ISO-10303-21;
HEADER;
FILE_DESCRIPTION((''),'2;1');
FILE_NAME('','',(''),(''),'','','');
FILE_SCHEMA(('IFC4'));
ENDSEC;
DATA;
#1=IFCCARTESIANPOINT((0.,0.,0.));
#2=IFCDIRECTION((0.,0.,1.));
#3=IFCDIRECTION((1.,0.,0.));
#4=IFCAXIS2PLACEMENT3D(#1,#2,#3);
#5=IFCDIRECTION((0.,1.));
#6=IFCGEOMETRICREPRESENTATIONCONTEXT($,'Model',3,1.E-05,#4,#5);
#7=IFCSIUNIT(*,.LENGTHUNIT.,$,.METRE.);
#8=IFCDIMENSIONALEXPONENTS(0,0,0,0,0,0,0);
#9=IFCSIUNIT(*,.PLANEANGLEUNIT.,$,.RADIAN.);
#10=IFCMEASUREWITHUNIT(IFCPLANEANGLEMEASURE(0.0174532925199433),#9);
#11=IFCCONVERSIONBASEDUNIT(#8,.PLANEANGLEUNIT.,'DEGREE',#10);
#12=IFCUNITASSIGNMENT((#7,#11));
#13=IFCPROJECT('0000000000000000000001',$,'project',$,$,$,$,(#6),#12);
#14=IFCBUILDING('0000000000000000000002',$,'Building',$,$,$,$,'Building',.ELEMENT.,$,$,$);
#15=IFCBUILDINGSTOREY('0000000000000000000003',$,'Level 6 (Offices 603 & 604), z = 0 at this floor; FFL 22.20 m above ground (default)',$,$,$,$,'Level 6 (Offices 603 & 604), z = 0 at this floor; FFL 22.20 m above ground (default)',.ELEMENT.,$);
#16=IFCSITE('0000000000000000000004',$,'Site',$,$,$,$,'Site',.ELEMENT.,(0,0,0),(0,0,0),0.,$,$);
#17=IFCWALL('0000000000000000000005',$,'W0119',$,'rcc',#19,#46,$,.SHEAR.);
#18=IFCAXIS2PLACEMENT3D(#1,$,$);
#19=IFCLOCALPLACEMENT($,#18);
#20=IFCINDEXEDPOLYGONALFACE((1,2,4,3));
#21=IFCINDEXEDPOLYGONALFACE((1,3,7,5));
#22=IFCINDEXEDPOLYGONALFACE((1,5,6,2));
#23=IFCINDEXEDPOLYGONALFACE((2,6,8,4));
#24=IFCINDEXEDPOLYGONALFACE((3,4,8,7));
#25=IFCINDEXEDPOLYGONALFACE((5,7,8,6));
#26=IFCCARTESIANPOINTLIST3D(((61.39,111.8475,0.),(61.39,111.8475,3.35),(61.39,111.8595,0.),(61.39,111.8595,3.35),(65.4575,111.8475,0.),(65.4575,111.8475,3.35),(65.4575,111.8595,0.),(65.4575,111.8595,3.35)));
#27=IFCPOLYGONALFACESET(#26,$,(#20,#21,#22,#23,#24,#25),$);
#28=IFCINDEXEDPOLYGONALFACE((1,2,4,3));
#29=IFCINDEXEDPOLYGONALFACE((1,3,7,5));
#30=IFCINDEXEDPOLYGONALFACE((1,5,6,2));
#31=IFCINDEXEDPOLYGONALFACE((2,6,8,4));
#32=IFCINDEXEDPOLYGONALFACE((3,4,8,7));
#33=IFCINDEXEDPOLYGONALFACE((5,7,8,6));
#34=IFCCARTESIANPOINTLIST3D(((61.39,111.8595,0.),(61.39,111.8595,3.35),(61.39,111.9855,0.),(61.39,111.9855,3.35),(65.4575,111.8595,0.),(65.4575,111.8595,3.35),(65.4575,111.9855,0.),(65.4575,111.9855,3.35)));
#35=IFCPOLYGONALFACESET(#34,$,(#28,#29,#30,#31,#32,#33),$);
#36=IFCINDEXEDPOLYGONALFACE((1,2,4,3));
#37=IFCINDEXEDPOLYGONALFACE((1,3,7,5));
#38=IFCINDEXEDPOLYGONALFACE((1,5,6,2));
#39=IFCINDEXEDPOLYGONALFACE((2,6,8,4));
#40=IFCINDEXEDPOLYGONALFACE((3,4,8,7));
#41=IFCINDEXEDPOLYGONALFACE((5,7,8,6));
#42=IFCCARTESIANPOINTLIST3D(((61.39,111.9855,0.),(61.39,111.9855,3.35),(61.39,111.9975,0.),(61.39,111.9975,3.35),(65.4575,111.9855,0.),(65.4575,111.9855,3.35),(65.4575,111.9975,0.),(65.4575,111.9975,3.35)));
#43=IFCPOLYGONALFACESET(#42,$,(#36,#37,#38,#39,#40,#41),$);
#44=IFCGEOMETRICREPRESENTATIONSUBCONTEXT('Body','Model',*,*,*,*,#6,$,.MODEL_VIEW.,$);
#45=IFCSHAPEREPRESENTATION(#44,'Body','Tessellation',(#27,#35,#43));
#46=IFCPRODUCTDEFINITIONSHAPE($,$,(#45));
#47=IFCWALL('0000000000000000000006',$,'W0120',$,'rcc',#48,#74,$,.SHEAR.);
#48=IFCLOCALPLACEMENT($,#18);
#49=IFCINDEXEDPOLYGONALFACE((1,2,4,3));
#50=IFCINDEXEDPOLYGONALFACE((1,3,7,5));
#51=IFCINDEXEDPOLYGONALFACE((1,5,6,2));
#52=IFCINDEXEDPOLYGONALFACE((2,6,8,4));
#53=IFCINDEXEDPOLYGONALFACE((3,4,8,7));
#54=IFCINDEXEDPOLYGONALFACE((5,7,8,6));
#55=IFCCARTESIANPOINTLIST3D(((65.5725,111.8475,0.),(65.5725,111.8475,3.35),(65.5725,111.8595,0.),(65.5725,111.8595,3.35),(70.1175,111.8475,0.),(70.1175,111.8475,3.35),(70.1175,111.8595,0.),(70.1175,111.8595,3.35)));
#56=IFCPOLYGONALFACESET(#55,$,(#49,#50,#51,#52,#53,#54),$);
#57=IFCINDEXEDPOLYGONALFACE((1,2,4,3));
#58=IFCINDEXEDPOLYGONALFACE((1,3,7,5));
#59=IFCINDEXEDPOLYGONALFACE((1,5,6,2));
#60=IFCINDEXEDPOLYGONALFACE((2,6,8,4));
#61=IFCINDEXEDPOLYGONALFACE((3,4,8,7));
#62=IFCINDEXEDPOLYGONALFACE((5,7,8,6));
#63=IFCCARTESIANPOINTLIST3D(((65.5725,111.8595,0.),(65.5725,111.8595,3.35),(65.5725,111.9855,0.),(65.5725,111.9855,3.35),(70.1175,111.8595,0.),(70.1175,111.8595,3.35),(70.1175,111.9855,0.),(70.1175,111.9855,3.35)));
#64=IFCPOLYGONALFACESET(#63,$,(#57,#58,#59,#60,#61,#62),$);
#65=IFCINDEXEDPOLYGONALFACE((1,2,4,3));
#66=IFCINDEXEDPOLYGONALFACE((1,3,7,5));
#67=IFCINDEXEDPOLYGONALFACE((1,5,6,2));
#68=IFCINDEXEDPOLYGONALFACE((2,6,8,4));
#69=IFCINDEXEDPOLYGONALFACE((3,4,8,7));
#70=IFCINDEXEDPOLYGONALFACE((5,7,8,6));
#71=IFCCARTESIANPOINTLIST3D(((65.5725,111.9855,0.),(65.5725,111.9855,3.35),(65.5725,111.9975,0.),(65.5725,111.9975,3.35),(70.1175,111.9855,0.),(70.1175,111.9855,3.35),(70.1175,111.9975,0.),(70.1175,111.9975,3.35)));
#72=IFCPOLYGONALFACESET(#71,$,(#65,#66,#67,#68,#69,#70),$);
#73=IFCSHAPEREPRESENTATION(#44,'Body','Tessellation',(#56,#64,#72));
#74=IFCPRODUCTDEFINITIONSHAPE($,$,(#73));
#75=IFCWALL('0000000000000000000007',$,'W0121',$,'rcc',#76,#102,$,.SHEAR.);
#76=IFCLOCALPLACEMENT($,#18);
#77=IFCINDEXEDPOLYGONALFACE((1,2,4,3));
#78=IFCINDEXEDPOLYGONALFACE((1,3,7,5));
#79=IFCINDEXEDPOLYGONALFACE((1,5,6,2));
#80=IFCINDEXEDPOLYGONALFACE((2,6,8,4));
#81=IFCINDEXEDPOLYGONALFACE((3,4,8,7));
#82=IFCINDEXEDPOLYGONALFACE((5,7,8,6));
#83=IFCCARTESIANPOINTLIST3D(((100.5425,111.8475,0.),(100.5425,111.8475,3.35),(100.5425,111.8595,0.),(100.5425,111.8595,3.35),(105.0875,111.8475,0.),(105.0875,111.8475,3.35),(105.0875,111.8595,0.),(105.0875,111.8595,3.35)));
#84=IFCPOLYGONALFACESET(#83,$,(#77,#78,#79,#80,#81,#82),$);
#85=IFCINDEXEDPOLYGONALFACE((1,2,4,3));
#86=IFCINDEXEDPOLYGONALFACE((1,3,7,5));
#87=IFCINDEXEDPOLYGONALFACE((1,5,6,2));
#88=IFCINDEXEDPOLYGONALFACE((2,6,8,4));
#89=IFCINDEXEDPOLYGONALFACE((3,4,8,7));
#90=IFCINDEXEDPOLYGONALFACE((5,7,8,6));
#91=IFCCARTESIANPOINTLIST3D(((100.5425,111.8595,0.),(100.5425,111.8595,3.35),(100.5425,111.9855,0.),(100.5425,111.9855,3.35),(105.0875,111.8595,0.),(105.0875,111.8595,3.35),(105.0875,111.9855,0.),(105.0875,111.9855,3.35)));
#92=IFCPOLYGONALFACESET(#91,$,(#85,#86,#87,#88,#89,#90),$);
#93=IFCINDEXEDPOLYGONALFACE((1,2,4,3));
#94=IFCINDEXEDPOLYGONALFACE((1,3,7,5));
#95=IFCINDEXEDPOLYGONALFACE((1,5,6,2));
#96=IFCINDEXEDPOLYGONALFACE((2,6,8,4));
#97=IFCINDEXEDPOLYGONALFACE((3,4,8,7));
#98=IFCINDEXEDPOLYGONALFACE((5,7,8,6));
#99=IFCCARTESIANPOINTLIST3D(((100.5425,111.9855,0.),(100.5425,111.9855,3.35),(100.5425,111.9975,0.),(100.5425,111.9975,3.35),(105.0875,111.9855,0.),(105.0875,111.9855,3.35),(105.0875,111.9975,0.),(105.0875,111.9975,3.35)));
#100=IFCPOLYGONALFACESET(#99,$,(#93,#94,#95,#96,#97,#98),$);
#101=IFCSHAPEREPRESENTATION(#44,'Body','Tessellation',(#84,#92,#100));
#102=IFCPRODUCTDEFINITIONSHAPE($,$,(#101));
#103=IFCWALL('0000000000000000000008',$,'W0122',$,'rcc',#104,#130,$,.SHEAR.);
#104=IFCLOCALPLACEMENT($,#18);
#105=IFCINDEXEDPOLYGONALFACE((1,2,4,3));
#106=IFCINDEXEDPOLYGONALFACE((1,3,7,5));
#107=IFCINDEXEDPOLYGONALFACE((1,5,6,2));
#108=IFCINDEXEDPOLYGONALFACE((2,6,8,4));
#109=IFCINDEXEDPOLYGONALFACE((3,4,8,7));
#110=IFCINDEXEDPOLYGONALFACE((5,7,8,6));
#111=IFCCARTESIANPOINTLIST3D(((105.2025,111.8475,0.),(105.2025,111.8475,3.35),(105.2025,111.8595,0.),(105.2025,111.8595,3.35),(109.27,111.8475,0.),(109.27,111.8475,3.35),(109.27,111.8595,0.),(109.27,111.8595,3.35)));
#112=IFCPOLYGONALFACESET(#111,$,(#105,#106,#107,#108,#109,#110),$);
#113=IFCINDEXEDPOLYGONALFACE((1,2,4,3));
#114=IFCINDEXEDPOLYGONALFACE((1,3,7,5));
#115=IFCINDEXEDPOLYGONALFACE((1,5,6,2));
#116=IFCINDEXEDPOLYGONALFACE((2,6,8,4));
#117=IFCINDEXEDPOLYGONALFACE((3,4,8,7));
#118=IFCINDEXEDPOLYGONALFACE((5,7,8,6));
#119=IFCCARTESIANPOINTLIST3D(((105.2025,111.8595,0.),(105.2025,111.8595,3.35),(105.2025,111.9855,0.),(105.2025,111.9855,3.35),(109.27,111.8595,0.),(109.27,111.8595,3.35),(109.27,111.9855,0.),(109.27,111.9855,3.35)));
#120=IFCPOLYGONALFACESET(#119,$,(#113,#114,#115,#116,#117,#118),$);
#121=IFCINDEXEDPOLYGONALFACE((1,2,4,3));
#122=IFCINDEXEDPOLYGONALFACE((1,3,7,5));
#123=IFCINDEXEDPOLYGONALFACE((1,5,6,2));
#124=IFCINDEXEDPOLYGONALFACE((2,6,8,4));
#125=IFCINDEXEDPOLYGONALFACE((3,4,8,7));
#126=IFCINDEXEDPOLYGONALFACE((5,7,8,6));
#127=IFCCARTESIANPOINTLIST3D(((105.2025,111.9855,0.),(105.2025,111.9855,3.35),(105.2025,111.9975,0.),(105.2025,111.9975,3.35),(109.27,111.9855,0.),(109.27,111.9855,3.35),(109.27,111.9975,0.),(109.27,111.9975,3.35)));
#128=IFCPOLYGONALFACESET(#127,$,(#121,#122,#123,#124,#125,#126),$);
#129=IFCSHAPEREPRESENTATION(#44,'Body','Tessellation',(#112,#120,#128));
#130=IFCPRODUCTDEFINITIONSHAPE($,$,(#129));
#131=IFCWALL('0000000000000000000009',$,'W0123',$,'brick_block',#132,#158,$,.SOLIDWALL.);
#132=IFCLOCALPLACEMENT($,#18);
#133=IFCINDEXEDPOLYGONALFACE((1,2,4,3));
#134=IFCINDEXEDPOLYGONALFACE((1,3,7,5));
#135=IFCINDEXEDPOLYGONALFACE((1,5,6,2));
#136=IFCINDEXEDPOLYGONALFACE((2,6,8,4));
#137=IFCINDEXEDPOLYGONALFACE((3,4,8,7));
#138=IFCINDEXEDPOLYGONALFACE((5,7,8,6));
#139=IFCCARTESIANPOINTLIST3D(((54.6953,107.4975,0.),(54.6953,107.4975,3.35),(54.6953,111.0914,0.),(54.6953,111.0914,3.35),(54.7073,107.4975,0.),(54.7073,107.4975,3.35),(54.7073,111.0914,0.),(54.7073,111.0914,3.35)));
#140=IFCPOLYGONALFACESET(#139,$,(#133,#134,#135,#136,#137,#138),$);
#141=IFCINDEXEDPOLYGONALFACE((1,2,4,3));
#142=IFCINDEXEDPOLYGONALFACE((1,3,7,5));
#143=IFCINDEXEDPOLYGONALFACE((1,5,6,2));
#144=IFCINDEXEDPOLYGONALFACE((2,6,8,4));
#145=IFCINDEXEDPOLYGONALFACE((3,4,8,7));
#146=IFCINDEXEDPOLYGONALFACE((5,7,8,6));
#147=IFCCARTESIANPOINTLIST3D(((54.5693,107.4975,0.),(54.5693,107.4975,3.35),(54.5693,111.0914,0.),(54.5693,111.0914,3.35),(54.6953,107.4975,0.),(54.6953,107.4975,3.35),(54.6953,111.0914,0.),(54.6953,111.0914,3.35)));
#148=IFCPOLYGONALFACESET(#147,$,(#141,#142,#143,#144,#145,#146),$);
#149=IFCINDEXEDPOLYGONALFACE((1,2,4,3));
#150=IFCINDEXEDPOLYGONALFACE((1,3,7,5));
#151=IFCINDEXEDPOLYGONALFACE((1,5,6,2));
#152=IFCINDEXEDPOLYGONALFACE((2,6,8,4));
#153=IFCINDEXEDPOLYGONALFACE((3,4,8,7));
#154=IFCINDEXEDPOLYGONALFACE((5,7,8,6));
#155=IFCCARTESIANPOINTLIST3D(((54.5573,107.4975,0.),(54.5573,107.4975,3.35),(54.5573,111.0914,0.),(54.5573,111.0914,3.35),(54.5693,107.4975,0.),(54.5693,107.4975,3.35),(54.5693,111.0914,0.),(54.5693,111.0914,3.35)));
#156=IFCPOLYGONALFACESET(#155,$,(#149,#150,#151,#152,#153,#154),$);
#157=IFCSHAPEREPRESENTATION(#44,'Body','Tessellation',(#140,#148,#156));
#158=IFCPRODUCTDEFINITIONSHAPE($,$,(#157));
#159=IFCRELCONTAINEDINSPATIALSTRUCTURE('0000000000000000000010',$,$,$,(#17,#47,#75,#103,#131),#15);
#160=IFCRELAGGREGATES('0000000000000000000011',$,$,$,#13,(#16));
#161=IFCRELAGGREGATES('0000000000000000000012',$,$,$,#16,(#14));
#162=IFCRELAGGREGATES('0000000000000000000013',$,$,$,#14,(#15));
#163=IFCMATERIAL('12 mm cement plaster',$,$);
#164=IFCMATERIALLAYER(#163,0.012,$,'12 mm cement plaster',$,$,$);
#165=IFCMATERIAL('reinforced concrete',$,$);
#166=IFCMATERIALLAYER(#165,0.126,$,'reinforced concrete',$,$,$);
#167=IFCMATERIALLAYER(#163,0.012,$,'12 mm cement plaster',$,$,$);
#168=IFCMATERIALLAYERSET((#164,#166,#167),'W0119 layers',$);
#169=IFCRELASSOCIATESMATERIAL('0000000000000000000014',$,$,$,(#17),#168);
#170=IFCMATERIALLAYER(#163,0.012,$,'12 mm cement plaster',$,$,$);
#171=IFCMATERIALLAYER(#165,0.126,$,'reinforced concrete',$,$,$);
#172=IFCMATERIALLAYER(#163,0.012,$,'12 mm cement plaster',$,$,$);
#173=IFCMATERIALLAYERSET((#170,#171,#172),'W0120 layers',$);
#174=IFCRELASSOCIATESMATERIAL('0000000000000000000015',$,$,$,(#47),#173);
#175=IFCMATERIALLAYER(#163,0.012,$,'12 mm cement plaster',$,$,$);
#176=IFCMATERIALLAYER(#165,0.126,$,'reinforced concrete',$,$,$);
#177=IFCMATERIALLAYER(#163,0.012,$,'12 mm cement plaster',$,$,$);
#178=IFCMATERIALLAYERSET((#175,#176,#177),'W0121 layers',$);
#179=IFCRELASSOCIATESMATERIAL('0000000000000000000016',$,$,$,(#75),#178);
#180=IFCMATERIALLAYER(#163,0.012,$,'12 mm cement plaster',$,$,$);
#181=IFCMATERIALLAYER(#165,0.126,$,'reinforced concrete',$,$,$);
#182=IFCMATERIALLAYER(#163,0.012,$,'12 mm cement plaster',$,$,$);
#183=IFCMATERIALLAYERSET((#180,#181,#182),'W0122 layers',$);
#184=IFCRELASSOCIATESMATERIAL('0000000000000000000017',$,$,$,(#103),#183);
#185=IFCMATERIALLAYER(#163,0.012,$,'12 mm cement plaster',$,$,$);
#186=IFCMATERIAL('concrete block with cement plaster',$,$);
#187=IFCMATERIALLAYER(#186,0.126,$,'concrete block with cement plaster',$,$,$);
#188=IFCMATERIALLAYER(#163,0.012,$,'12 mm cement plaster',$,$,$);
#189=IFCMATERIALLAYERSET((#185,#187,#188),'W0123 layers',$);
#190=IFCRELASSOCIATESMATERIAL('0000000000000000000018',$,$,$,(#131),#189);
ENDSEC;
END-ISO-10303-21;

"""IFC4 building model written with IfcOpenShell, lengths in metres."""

from ifc_helpers import new_model, entity, si_unit, converted_unit, direction, frame, frame_2d, origin_with_axes, origin_2d_with_axis, place, context, subcontext, project, spatial, rectangle, extrude, material, layer, layer_set, layer_usage, element, save


model = new_model("IFC4")

# Units and contexts
model_context = context("Model", 3, precision=1e-05, world=origin_with_axes(), true_north=direction((0.0, 1.0)))
body_context = subcontext(model_context, "Body", "Model", "MODEL_VIEW")
ifc_project = project(units=[si_unit("LENGTHUNIT", "METRE"), converted_unit("PLANEANGLEUNIT", "DEGREE", entity("IfcPlaneAngleMeasure", 0.0174532925199433), si_unit("PLANEANGLEUNIT", "RADIAN"), dimensions=[0, 0, 0, 0, 0, 0, 0])], contexts=[model_context])

# Site, building, storey
site = spatial("IfcSite", under=ifc_project, Name="Site", LongName="Site", CompositionType="ELEMENT", RefLatitude=(0, 0, 0), RefLongitude=(0, 0, 0), RefElevation=0.0)
building = spatial("IfcBuilding", under=site, Name="Building", LongName="Building", CompositionType="ELEMENT")
storey = spatial("IfcBuildingStorey", under=building, Name="Level 6 (Offices 603 & 604), z = 0 at this floor; FFL 22.20 m above ground (default)", LongName="Level 6 (Offices 603 & 604), z = 0 at this floor; FFL 22.20 m above ground (default)", CompositionType="ELEMENT")

# Shared definitions
placement = place(None, origin_with_axes())

# Walls
ifc_material_1 = material(Name="12 mm cement plaster")
ifc_material_2 = material(Name="concrete block with cement plaster")
ifc_layer_1 = layer(ifc_material_1, 0.012, Name="12 mm cement plaster")
ifc_material_3 = material(Name="reinforced concrete")
ifc_layer_2 = layer(ifc_material_3, 0.126, Name="reinforced concrete")
ifc_layer_3 = layer(ifc_material_1, 0.012, Name="12 mm cement plaster")
ifc_layer_set_1 = layer_set([ifc_layer_1, ifc_layer_2, ifc_layer_3], Name="W0119 layers")
ifc_layer_usage_1 = layer_usage(ifc_layer_set_1, "AXIS2", "POSITIVE", -0.075)
element("IfcWall", 1, at=placement, inside=storey, material=ifc_layer_usage_1, Name="W0119", ObjectType="rcc", PredefinedType="SHEAR", context=body_context, shape_type="SweptSolid", body=[
    extrude(rectangle(XDim=4.0675, YDim=0.012, at=frame_2d((0.0, 0.0), x_axis=(1.0, 0.0))), frame((63.4237, 111.8535, 0.0), z_axis=(0.0, 0.0, 1.0), x_axis=(1.0, 0.0, 0.0)), (0.0, 0.0, 1.0), 3.35),
    extrude(rectangle(XDim=4.0675, YDim=0.126, at=frame_2d((0.0, 0.069), x_axis=(1.0, 0.0))), frame((63.4237, 111.8535, 0.0), z_axis=(0.0, 0.0, 1.0), x_axis=(1.0, 0.0, 0.0)), (0.0, 0.0, 1.0), 3.35),
    extrude(rectangle(XDim=4.0675, YDim=0.012, at=frame_2d((0.0, 0.138), x_axis=(1.0, 0.0))), frame((63.4237, 111.8535, 0.0), z_axis=(0.0, 0.0, 1.0), x_axis=(1.0, 0.0, 0.0)), (0.0, 0.0, 1.0), 3.35),
])
ifc_layer_4 = layer(ifc_material_1, 0.012, Name="12 mm cement plaster")
ifc_layer_5 = layer(ifc_material_3, 0.126, Name="reinforced concrete")
ifc_layer_6 = layer(ifc_material_1, 0.012, Name="12 mm cement plaster")
ifc_layer_set_2 = layer_set([ifc_layer_4, ifc_layer_5, ifc_layer_6], Name="W0120 layers")
ifc_layer_usage_2 = layer_usage(ifc_layer_set_2, "AXIS2", "POSITIVE", -0.075)
element("IfcWall", 2, at=placement, inside=storey, material=ifc_layer_usage_2, Name="W0120", ObjectType="rcc", PredefinedType="SHEAR", context=body_context, shape_type="SweptSolid", body=[
    extrude(rectangle(XDim=4.545, YDim=0.012, at=origin_2d_with_axis()), frame((67.845, 111.8535, 0.0), z_axis=(0.0, 0.0, 1.0), x_axis=(1.0, 0.0, 0.0)), (0.0, 0.0, 1.0), 3.35),
    extrude(rectangle(XDim=4.545, YDim=0.126, at=frame_2d((0.0, 0.069), x_axis=(1.0, 0.0))), frame((67.845, 111.8535, 0.0), z_axis=(0.0, 0.0, 1.0), x_axis=(1.0, 0.0, 0.0)), (0.0, 0.0, 1.0), 3.35),
    extrude(rectangle(XDim=4.545, YDim=0.012, at=frame_2d((0.0, 0.138), x_axis=(1.0, 0.0))), frame((67.845, 111.8535, 0.0), z_axis=(0.0, 0.0, 1.0), x_axis=(1.0, 0.0, 0.0)), (0.0, 0.0, 1.0), 3.35),
])
ifc_layer_7 = layer(ifc_material_1, 0.012, Name="12 mm cement plaster")
ifc_layer_8 = layer(ifc_material_3, 0.126, Name="reinforced concrete")
ifc_layer_9 = layer(ifc_material_1, 0.012, Name="12 mm cement plaster")
ifc_layer_set_3 = layer_set([ifc_layer_7, ifc_layer_8, ifc_layer_9], Name="W0121 layers")
ifc_layer_usage_3 = layer_usage(ifc_layer_set_3, "AXIS2", "POSITIVE", -0.075)
element("IfcWall", 3, at=placement, inside=storey, material=ifc_layer_usage_3, Name="W0121", ObjectType="rcc", PredefinedType="SHEAR", context=body_context, shape_type="SweptSolid", body=[
    extrude(rectangle(XDim=4.545, YDim=0.012, at=origin_2d_with_axis()), frame((102.815, 111.8535, 0.0), z_axis=(0.0, 0.0, 1.0), x_axis=(1.0, 0.0, 0.0)), (0.0, 0.0, 1.0), 3.35),
    extrude(rectangle(XDim=4.545, YDim=0.126, at=frame_2d((0.0, 0.069), x_axis=(1.0, 0.0))), frame((102.815, 111.8535, 0.0), z_axis=(0.0, 0.0, 1.0), x_axis=(1.0, 0.0, 0.0)), (0.0, 0.0, 1.0), 3.35),
    extrude(rectangle(XDim=4.545, YDim=0.012, at=frame_2d((0.0, 0.138), x_axis=(1.0, 0.0))), frame((102.815, 111.8535, 0.0), z_axis=(0.0, 0.0, 1.0), x_axis=(1.0, 0.0, 0.0)), (0.0, 0.0, 1.0), 3.35),
])
ifc_layer_10 = layer(ifc_material_1, 0.012, Name="12 mm cement plaster")
ifc_layer_11 = layer(ifc_material_3, 0.126, Name="reinforced concrete")
ifc_layer_12 = layer(ifc_material_1, 0.012, Name="12 mm cement plaster")
ifc_layer_set_4 = layer_set([ifc_layer_10, ifc_layer_11, ifc_layer_12], Name="W0122 layers")
ifc_layer_usage_4 = layer_usage(ifc_layer_set_4, "AXIS2", "POSITIVE", -0.075)
element("IfcWall", 4, at=placement, inside=storey, material=ifc_layer_usage_4, Name="W0122", ObjectType="rcc", PredefinedType="SHEAR", context=body_context, shape_type="SweptSolid", body=[
    extrude(rectangle(XDim=4.0675, YDim=0.012, at=frame_2d((0.0, 0.0), x_axis=(1.0, 0.0))), frame((107.2362, 111.8535, 0.0), z_axis=(0.0, 0.0, 1.0), x_axis=(1.0, 0.0, 0.0)), (0.0, 0.0, 1.0), 3.35),
    extrude(rectangle(XDim=4.0675, YDim=0.126, at=frame_2d((0.0, 0.069), x_axis=(1.0, 0.0))), frame((107.2362, 111.8535, 0.0), z_axis=(0.0, 0.0, 1.0), x_axis=(1.0, 0.0, 0.0)), (0.0, 0.0, 1.0), 3.35),
    extrude(rectangle(XDim=4.0675, YDim=0.012, at=frame_2d((0.0, 0.138), x_axis=(1.0, 0.0))), frame((107.2362, 111.8535, 0.0), z_axis=(0.0, 0.0, 1.0), x_axis=(1.0, 0.0, 0.0)), (0.0, 0.0, 1.0), 3.35),
])
ifc_layer_13 = layer(ifc_material_1, 0.012, Name="12 mm cement plaster")
ifc_layer_14 = layer(ifc_material_2, 0.126, Name="concrete block with cement plaster")
ifc_layer_15 = layer(ifc_material_1, 0.012, Name="12 mm cement plaster")
ifc_layer_set_5 = layer_set([ifc_layer_13, ifc_layer_14, ifc_layer_15], Name="W0123 layers")
ifc_layer_usage_5 = layer_usage(ifc_layer_set_5, "AXIS2", "POSITIVE", -0.075)
element("IfcWall", 5, at=placement, inside=storey, material=ifc_layer_usage_5, Name="W0123", ObjectType="brick_block", PredefinedType="SOLIDWALL", context=body_context, shape_type="SweptSolid", body=[
    extrude(rectangle(XDim=3.5939, YDim=0.012, at=frame_2d((0.0, 0.0), x_axis=(0.0, 1.0))), frame((54.7013, 109.2944, 0.0), z_axis=(0.0, 0.0, 1.0), x_axis=(1.0, 0.0, 0.0)), (0.0, 0.0, 1.0), 3.35),
    extrude(rectangle(XDim=3.5939, YDim=0.126, at=frame_2d((-0.069, 0.0), x_axis=(0.0, 1.0))), frame((54.7013, 109.2944, 0.0), z_axis=(0.0, 0.0, 1.0), x_axis=(1.0, 0.0, 0.0)), (0.0, 0.0, 1.0), 3.35),
    extrude(rectangle(XDim=3.5939, YDim=0.012, at=frame_2d((-0.138, 0.0), x_axis=(0.0, 1.0))), frame((54.7013, 109.2944, 0.0), z_axis=(0.0, 0.0, 1.0), x_axis=(1.0, 0.0, 0.0)), (0.0, 0.0, 1.0), 3.35),
])

save(model, "model.ifc")
